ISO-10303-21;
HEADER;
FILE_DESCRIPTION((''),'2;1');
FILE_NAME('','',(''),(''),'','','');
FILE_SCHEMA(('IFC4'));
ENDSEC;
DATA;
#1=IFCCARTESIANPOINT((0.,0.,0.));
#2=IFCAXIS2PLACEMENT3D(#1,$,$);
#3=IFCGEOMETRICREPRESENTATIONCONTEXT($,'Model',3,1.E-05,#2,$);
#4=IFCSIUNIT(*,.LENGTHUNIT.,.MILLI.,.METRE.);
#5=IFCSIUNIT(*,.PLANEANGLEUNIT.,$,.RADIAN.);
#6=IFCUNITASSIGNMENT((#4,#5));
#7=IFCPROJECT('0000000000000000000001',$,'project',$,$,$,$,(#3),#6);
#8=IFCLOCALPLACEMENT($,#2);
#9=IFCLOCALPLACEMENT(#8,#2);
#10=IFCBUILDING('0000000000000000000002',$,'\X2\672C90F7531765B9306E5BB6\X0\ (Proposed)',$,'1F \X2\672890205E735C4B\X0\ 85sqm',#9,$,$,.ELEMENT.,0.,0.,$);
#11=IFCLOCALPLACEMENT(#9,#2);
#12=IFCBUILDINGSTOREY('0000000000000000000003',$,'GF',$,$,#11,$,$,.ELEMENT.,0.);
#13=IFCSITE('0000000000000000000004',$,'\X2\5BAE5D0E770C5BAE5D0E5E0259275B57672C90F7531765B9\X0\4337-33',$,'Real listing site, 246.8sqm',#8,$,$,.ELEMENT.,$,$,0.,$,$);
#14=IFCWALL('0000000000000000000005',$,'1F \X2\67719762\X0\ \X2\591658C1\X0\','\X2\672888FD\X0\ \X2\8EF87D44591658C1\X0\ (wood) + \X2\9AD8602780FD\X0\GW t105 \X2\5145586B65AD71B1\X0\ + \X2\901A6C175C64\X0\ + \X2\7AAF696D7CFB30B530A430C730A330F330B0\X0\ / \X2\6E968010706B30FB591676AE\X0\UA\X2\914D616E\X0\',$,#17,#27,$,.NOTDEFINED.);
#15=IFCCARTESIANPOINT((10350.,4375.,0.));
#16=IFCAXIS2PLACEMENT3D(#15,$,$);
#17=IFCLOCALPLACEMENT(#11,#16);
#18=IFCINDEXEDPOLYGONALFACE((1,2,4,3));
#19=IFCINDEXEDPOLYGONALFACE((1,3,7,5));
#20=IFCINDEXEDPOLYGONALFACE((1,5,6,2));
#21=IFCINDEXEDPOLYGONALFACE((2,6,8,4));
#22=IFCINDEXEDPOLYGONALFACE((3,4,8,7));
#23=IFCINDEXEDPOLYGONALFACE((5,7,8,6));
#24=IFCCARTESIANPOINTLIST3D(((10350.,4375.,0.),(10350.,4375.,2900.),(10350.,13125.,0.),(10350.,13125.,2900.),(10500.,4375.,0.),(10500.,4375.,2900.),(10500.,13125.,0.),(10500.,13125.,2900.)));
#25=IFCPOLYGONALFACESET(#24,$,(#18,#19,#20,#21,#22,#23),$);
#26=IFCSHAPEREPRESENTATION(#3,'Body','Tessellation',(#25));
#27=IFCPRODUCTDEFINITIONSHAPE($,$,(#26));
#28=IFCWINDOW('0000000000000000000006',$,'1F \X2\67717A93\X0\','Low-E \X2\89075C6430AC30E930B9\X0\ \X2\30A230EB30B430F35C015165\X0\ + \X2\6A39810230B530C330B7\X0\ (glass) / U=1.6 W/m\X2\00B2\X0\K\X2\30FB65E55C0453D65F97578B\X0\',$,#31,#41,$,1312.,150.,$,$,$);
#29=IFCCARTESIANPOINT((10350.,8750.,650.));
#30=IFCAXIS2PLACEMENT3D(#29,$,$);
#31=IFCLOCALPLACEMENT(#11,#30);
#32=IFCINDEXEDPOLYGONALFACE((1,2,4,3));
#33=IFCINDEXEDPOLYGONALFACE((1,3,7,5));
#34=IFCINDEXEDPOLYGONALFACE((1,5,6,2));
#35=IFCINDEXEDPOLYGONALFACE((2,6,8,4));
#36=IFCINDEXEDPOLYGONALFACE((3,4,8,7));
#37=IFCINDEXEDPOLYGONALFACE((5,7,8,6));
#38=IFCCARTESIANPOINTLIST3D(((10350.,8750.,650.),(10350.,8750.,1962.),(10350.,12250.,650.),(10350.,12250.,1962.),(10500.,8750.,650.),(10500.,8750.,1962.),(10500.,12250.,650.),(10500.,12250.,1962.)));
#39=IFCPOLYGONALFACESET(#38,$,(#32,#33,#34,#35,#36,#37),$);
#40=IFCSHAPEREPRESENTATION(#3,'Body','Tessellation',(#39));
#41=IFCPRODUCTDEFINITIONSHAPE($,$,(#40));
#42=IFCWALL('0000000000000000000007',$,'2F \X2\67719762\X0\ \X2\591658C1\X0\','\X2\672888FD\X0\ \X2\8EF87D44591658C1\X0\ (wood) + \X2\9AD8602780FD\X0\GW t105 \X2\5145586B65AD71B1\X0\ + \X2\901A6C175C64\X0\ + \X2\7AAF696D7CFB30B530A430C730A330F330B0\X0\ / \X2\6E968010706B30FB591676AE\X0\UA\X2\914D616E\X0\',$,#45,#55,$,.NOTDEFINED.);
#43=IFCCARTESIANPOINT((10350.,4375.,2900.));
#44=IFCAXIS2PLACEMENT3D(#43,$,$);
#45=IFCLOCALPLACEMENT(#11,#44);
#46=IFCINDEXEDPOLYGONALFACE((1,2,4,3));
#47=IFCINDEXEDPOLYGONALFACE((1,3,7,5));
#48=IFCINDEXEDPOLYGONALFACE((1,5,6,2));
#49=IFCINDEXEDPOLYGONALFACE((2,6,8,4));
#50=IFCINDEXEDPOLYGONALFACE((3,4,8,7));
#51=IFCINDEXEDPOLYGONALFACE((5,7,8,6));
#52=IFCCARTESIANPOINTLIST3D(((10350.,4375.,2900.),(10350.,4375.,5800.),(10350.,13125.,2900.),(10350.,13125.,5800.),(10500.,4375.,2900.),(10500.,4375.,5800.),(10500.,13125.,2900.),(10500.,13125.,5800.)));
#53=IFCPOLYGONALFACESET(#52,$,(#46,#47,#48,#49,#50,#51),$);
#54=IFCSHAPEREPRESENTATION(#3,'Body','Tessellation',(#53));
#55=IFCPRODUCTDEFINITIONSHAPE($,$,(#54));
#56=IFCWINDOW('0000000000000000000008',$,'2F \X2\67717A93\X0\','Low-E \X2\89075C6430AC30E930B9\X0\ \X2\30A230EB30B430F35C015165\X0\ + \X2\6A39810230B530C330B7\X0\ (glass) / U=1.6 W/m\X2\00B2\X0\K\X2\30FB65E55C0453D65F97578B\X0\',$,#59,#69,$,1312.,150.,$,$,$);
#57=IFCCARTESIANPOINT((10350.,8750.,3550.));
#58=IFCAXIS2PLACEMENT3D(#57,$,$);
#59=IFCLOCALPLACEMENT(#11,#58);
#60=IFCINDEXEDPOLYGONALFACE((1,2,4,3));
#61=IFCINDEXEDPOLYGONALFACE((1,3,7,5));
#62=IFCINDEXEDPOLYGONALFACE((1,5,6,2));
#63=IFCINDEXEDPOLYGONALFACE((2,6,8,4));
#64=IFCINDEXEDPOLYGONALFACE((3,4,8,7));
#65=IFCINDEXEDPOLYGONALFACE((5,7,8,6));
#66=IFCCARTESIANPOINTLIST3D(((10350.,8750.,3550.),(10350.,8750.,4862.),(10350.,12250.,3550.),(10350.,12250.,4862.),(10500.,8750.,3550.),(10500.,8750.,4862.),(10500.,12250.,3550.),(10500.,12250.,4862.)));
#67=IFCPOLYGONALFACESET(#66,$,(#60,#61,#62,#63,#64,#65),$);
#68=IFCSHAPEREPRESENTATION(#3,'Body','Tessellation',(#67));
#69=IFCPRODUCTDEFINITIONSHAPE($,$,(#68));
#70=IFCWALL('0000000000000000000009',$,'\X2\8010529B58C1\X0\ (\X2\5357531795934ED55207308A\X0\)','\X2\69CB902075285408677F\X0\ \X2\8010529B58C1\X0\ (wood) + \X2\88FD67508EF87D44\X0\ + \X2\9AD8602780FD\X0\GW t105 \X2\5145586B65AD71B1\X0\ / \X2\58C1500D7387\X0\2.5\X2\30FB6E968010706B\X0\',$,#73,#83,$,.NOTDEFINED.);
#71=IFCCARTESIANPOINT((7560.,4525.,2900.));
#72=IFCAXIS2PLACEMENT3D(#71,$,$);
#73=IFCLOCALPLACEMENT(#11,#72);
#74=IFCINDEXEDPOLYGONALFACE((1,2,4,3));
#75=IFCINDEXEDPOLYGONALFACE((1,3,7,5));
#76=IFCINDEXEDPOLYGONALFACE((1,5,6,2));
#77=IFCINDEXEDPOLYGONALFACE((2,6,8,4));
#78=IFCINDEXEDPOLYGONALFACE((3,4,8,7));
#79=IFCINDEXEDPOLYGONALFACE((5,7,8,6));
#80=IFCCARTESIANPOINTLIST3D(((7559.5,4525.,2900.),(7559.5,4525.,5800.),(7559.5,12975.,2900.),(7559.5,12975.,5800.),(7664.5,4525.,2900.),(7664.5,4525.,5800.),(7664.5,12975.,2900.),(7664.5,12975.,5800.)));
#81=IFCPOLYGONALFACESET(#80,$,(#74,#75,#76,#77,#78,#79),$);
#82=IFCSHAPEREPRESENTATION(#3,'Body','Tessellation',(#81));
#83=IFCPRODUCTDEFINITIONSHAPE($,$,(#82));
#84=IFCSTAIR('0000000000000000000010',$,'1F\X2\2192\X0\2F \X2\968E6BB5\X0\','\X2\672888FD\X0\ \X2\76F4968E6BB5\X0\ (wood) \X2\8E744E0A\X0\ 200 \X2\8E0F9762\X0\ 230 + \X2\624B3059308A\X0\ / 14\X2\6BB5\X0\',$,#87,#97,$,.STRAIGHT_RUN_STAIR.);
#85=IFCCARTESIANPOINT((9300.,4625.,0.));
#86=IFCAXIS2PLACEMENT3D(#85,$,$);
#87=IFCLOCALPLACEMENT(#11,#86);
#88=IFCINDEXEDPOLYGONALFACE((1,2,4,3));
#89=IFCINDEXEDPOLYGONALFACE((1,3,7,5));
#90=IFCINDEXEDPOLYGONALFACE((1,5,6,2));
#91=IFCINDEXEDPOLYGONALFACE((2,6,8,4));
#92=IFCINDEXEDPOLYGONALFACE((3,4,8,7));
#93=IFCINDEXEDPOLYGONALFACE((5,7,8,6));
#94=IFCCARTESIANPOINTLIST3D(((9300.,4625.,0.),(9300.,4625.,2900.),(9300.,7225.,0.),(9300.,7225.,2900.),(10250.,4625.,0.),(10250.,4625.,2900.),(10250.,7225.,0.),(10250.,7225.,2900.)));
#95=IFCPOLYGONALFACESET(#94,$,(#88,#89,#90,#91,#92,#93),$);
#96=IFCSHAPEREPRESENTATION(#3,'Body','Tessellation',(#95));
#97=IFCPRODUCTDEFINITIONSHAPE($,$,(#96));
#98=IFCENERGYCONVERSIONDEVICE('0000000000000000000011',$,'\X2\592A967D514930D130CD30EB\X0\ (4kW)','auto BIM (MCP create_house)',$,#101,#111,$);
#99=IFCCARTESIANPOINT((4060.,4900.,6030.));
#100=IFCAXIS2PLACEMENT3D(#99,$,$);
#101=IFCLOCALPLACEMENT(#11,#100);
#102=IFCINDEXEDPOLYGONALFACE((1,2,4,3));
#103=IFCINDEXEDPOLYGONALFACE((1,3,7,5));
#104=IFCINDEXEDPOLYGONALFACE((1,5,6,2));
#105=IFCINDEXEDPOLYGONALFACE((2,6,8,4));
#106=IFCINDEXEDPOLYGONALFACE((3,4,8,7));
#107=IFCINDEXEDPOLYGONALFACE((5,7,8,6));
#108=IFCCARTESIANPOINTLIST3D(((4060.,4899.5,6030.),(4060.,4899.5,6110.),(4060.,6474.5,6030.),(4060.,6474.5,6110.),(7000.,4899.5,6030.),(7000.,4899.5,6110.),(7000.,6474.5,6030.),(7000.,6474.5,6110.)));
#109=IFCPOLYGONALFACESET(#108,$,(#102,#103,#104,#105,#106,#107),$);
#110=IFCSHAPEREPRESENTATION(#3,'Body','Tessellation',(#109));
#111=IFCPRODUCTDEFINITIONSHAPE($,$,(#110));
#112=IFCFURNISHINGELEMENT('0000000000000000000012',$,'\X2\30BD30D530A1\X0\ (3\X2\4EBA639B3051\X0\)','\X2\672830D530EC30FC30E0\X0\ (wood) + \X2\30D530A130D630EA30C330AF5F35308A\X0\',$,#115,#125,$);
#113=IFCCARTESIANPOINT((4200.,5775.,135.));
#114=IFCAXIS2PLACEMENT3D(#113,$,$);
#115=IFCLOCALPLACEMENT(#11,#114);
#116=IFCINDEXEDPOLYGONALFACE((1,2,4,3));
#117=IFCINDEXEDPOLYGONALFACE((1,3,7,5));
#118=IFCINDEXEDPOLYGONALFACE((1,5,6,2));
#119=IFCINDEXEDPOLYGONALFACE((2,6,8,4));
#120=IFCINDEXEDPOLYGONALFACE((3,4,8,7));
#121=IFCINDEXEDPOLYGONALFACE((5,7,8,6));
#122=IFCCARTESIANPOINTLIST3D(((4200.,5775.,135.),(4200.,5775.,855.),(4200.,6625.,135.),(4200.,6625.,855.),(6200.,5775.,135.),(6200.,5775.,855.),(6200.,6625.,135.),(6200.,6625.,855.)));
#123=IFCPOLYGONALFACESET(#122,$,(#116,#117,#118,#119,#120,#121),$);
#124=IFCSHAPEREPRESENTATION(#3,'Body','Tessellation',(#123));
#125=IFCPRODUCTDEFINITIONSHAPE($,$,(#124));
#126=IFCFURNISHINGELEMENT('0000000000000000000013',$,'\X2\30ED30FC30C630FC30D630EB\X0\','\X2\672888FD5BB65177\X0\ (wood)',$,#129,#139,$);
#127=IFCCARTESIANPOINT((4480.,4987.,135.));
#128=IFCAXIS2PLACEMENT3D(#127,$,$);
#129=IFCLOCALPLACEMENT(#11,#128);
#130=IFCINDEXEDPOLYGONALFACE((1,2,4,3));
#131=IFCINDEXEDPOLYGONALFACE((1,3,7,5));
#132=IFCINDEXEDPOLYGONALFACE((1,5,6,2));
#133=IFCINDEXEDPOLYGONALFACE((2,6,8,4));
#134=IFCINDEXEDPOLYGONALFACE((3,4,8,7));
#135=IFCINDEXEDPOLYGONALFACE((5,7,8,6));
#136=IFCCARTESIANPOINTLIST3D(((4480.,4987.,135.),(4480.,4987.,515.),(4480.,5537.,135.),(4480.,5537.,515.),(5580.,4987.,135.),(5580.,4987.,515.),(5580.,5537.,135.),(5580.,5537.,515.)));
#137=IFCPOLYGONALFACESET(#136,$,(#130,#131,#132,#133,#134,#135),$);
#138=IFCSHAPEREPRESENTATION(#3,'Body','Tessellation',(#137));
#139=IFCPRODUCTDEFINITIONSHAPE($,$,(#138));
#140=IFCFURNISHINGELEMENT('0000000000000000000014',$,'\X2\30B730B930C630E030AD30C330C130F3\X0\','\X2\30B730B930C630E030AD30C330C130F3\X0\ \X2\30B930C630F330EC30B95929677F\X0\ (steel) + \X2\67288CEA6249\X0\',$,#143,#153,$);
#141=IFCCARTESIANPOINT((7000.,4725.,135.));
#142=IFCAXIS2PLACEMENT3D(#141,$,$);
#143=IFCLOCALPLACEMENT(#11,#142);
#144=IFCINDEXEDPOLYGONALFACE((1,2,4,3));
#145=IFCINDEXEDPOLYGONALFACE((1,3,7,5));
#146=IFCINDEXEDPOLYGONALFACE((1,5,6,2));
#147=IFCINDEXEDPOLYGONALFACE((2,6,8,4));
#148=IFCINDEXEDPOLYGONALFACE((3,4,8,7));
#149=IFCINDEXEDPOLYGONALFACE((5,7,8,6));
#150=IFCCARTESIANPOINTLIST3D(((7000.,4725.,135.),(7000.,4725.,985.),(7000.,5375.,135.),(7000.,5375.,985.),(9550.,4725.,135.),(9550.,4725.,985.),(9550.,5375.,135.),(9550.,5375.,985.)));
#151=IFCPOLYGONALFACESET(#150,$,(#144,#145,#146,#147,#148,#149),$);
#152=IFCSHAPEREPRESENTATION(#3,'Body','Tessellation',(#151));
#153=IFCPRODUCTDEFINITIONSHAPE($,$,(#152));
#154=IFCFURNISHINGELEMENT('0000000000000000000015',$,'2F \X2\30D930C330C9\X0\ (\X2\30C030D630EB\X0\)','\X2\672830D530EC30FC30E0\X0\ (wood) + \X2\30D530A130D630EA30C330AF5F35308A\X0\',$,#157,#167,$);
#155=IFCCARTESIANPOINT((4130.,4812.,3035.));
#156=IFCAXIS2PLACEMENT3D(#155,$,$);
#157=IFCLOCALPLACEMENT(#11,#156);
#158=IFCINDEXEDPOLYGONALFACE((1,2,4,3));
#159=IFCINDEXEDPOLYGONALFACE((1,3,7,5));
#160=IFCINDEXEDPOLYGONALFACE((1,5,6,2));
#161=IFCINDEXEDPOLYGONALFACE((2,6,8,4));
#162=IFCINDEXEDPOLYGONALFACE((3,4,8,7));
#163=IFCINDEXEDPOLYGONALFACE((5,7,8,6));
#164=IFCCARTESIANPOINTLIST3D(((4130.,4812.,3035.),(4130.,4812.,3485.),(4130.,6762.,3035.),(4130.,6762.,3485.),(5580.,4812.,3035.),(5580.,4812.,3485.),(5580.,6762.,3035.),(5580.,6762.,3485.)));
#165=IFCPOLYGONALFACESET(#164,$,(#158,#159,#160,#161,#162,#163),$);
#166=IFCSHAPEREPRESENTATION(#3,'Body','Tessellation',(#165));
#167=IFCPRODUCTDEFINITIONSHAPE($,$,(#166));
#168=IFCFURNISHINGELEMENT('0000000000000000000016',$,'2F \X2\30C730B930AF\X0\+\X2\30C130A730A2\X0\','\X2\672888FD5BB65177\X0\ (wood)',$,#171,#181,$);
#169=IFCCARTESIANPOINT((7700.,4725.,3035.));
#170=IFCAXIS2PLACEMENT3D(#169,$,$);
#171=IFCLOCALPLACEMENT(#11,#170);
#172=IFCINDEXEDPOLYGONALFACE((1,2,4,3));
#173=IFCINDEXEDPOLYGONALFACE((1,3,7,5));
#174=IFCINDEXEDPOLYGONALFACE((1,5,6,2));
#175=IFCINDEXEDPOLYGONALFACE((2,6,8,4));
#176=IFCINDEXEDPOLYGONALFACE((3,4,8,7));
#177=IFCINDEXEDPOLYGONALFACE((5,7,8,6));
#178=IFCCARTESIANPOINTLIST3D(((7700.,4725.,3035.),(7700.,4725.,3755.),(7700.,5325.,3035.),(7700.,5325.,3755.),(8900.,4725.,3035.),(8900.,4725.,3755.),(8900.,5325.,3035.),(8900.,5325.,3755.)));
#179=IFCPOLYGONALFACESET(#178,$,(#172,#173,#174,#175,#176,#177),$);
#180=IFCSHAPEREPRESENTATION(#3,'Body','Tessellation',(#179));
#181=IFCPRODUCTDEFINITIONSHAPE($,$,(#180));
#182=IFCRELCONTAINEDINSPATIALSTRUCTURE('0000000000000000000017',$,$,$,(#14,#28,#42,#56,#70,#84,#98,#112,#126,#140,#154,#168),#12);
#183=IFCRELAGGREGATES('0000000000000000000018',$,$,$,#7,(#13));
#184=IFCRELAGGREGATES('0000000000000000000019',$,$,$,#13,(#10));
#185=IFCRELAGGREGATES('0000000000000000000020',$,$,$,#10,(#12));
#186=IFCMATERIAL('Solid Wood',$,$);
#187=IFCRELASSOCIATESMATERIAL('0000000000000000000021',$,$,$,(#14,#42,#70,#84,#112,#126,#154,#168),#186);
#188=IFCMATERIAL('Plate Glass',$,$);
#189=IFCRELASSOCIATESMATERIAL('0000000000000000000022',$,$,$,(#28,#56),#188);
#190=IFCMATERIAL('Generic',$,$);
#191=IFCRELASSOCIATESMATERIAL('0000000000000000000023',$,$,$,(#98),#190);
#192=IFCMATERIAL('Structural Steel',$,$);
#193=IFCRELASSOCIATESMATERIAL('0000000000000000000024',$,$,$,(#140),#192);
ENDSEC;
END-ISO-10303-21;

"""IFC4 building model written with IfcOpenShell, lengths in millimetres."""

from ifc_helpers import new_model, si_unit, frame, frame_2d, origin, place, context, project, spatial, rectangle, extrude, material, element, fill, save


model = new_model("IFC4")

# Units and contexts
model_context = context("Model", 3, precision=1e-05, world=origin())
ifc_project = project(units=[si_unit("LENGTHUNIT", "METRE", prefix="MILLI"), si_unit("PLANEANGLEUNIT", "RADIAN")], contexts=[model_context])

# Site, building, storey
site_placement = place(None, origin())
site = spatial("IfcSite", under=ifc_project, at=site_placement, Name="宮崎県宮崎市大字本郷北方4337-33", ObjectType="Real listing site, 246.8sqm", CompositionType="ELEMENT", RefElevation=0.0)
building_placement = place(site_placement, origin())
building = spatial("IfcBuilding", under=site, at=building_placement, Name="本郷北方の家 (Proposed)", ObjectType="1F 木造平屋 85sqm", CompositionType="ELEMENT", ElevationOfRefHeight=0.0, ElevationOfTerrain=0.0)
storey_placement = place(building_placement, origin())
storey = spatial("IfcBuildingStorey", under=building, at=storey_placement, Name="GF", CompositionType="ELEMENT", Elevation=0.0)

# Wall, opening, window
ifc_material_1 = material(Name="Solid Wood")
wall_1_placement = place(storey_placement, frame((10350.0, 4375.0, 0.0)))
wall_1 = element("IfcWall", 1, at=wall_1_placement, inside=storey, material=ifc_material_1, Name="1F 東面 外壁", Description="木製 軸組外壁 (wood) + 高性能GW t105 充填断熱 + 通気層 + 窯業系サイディング / 準耐火・外皮UA配慮", PredefinedType="NOTDEFINED", context=model_context, shape_type="SweptSolid", body=[
    extrude(rectangle(XDim=150.0, YDim=8750.0, at=frame_2d((75.0, 4375.0))), frame((10350.0, 4375.0, 0.0)), (0.0, 0.0, 1.0), 2900.0),
])
opening_1_placement = place(storey_placement, frame((10350.0, 8750.0, 650.0)))
opening_1 = element("IfcOpeningElement", 2, at=opening_1_placement, cuts=wall_1, PredefinedType="NOTDEFINED", context=model_context, shape_type="SweptSolid", body=[
    extrude(rectangle(XDim=150.0, YDim=3500.0, at=frame_2d((75.0, 1750.0))), frame((10350.0, 8750.0, 650.0)), (0.0, 0.0, 1.0), 1312.0),
])
ifc_material_2 = material(Name="Plate Glass")
window_1_placement = place(storey_placement, frame((10350.0, 8750.0, 650.0)))
window_1 = element("IfcWindow", 3, at=window_1_placement, inside=storey, material=ifc_material_2, Name="1F 東窓", Description="Low-E 複層ガラス アルゴン封入 + 樹脂サッシ (glass) / U=1.6 W/m²K・日射取得型", OverallHeight=1312.0, OverallWidth=150.0, context=model_context, shape_type="SweptSolid", body=[
    extrude(rectangle(XDim=150.0, YDim=3500.0, at=frame_2d((75.0, 1750.0))), frame((10350.0, 8750.0, 650.0)), (0.0, 0.0, 1.0), 1312.0),
])
fill(opening_1, window_1)

# Wall, opening, window
wall_2_placement = place(storey_placement, frame((10350.0, 4375.0, 2900.0)))
wall_2 = element("IfcWall", 4, at=wall_2_placement, inside=storey, material=ifc_material_1, Name="2F 東面 外壁", Description="木製 軸組外壁 (wood) + 高性能GW t105 充填断熱 + 通気層 + 窯業系サイディング / 準耐火・外皮UA配慮", PredefinedType="NOTDEFINED", context=model_context, shape_type="SweptSolid", body=[
    extrude(rectangle(XDim=150.0, YDim=8750.0, at=frame_2d((75.0, 4375.0))), frame((10350.0, 4375.0, 2900.0)), (0.0, 0.0, 1.0), 2900.0),
])
opening_2_placement = place(storey_placement, frame((10350.0, 8750.0, 3550.0)))
opening_2 = element("IfcOpeningElement", 5, at=opening_2_placement, cuts=wall_2, PredefinedType="NOTDEFINED", context=model_context, shape_type="SweptSolid", body=[
    extrude(rectangle(XDim=150.0, YDim=3500.0, at=frame_2d((75.0, 1750.0))), frame((10350.0, 8750.0, 3550.0)), (0.0, 0.0, 1.0), 1312.0),
])
window_2_placement = place(storey_placement, frame((10350.0, 8750.0, 3550.0)))
window_2 = element("IfcWindow", 6, at=window_2_placement, inside=storey, material=ifc_material_2, Name="2F 東窓", Description="Low-E 複層ガラス アルゴン封入 + 樹脂サッシ (glass) / U=1.6 W/m²K・日射取得型", OverallHeight=1312.0, OverallWidth=150.0, context=model_context, shape_type="SweptSolid", body=[
    extrude(rectangle(XDim=150.0, YDim=3500.0, at=frame_2d((75.0, 1750.0))), frame((10350.0, 8750.0, 3550.0)), (0.0, 0.0, 1.0), 1312.0),
])
fill(opening_2, window_2)

# Wall
wall_3_placement = place(storey_placement, frame((7560.0, 4525.0, 2900.0)))
element("IfcWall", 7, at=wall_3_placement, inside=storey, material=ifc_material_1, Name="耐力壁 (南北間仕切り)", Description="構造用合板 耐力壁 (wood) + 製材軸組 + 高性能GW t105 充填断熱 / 壁倍率2.5・準耐火", PredefinedType="NOTDEFINED", context=model_context, shape_type="SweptSolid", body=[
    extrude(rectangle(XDim=105.0, YDim=8450.0, at=frame_2d((52.0, 4225.0))), frame((7560.0, 4525.0, 2900.0)), (0.0, 0.0, 1.0), 2900.0),
])

# Stair
stair_placement = place(storey_placement, frame((9300.0, 4625.0, 0.0)))
element("IfcStair", 8, at=stair_placement, inside=storey, material=ifc_material_1, Name="1F→2F 階段", Description="木製 直階段 (wood) 蹴上 200 踏面 230 + 手すり / 14段", PredefinedType="STRAIGHT_RUN_STAIR", context=model_context, shape_type="SweptSolid", body=[
    extrude(rectangle(XDim=950.0, YDim=2600.0, at=frame_2d((475.0, 1300.0))), frame((9300.0, 4625.0, 0.0)), (0.0, 0.0, 1.0), 2900.0),
])

# Energy conversion device
ifc_material_3 = material(Name="Generic")
energy_conversion_device_placement = place(storey_placement, frame((4060.0, 4900.0, 6030.0)))
element("IfcEnergyConversionDevice", 9, at=energy_conversion_device_placement, inside=storey, material=ifc_material_3, Name="太陽光パネル (4kW)", Description="auto BIM (MCP create_house)", context=model_context, shape_type="SweptSolid", body=[
    extrude(rectangle(XDim=2940.0, YDim=1575.0, at=frame_2d((1470.0, 787.0))), frame((4060.0, 4900.0, 6030.0)), (0.0, 0.0, 1.0), 80.0),
])

# Furnishing elements
furnishing_1_placement = place(storey_placement, frame((4200.0, 5775.0, 135.0)))
element("IfcFurnishingElement", 10, at=furnishing_1_placement, inside=storey, material=ifc_material_1, Name="ソファ (3人掛け)", Description="木フレーム (wood) + ファブリック張り", context=model_context, shape_type="SweptSolid", body=[
    extrude(rectangle(XDim=2000.0, YDim=850.0, at=frame_2d((1000.0, 425.0))), frame((4200.0, 5775.0, 135.0)), (0.0, 0.0, 1.0), 720.0),
])
furnishing_2_placement = place(storey_placement, frame((4480.0, 4987.0, 135.0)))
element("IfcFurnishingElement", 11, at=furnishing_2_placement, inside=storey, material=ifc_material_1, Name="ローテーブル", Description="木製家具 (wood)", context=model_context, shape_type="SweptSolid", body=[
    extrude(rectangle(XDim=1100.0, YDim=550.0, at=frame_2d((550.0, 275.0))), frame((4480.0, 4987.0, 135.0)), (0.0, 0.0, 1.0), 380.0),
])
ifc_material_4 = material(Name="Structural Steel")
furnishing_3_placement = place(storey_placement, frame((7000.0, 4725.0, 135.0)))
element("IfcFurnishingElement", 12, at=furnishing_3_placement, inside=storey, material=ifc_material_4, Name="システムキッチン", Description="システムキッチン ステンレス天板 (steel) + 木質扉", context=model_context, shape_type="SweptSolid", body=[
    extrude(rectangle(XDim=2550.0, YDim=650.0, at=frame_2d((1275.0, 325.0))), frame((7000.0, 4725.0, 135.0)), (0.0, 0.0, 1.0), 850.0),
])
furnishing_4_placement = place(storey_placement, frame((4130.0, 4812.0, 3035.0)))
element("IfcFurnishingElement", 13, at=furnishing_4_placement, inside=storey, material=ifc_material_1, Name="2F ベッド (ダブル)", Description="木フレーム (wood) + ファブリック張り", context=model_context, shape_type="SweptSolid", body=[
    extrude(rectangle(XDim=1450.0, YDim=1950.0, at=frame_2d((725.0, 975.0))), frame((4130.0, 4812.0, 3035.0)), (0.0, 0.0, 1.0), 450.0),
])
furnishing_5_placement = place(storey_placement, frame((7700.0, 4725.0, 3035.0)))
element("IfcFurnishingElement", 14, at=furnishing_5_placement, inside=storey, material=ifc_material_1, Name="2F デスク+チェア", Description="木製家具 (wood)", context=model_context, shape_type="SweptSolid", body=[
    extrude(rectangle(XDim=1200.0, YDim=600.0, at=frame_2d((600.0, 300.0))), frame((7700.0, 4725.0, 3035.0)), (0.0, 0.0, 1.0), 720.0),
])

save(model, "model.ifc")
